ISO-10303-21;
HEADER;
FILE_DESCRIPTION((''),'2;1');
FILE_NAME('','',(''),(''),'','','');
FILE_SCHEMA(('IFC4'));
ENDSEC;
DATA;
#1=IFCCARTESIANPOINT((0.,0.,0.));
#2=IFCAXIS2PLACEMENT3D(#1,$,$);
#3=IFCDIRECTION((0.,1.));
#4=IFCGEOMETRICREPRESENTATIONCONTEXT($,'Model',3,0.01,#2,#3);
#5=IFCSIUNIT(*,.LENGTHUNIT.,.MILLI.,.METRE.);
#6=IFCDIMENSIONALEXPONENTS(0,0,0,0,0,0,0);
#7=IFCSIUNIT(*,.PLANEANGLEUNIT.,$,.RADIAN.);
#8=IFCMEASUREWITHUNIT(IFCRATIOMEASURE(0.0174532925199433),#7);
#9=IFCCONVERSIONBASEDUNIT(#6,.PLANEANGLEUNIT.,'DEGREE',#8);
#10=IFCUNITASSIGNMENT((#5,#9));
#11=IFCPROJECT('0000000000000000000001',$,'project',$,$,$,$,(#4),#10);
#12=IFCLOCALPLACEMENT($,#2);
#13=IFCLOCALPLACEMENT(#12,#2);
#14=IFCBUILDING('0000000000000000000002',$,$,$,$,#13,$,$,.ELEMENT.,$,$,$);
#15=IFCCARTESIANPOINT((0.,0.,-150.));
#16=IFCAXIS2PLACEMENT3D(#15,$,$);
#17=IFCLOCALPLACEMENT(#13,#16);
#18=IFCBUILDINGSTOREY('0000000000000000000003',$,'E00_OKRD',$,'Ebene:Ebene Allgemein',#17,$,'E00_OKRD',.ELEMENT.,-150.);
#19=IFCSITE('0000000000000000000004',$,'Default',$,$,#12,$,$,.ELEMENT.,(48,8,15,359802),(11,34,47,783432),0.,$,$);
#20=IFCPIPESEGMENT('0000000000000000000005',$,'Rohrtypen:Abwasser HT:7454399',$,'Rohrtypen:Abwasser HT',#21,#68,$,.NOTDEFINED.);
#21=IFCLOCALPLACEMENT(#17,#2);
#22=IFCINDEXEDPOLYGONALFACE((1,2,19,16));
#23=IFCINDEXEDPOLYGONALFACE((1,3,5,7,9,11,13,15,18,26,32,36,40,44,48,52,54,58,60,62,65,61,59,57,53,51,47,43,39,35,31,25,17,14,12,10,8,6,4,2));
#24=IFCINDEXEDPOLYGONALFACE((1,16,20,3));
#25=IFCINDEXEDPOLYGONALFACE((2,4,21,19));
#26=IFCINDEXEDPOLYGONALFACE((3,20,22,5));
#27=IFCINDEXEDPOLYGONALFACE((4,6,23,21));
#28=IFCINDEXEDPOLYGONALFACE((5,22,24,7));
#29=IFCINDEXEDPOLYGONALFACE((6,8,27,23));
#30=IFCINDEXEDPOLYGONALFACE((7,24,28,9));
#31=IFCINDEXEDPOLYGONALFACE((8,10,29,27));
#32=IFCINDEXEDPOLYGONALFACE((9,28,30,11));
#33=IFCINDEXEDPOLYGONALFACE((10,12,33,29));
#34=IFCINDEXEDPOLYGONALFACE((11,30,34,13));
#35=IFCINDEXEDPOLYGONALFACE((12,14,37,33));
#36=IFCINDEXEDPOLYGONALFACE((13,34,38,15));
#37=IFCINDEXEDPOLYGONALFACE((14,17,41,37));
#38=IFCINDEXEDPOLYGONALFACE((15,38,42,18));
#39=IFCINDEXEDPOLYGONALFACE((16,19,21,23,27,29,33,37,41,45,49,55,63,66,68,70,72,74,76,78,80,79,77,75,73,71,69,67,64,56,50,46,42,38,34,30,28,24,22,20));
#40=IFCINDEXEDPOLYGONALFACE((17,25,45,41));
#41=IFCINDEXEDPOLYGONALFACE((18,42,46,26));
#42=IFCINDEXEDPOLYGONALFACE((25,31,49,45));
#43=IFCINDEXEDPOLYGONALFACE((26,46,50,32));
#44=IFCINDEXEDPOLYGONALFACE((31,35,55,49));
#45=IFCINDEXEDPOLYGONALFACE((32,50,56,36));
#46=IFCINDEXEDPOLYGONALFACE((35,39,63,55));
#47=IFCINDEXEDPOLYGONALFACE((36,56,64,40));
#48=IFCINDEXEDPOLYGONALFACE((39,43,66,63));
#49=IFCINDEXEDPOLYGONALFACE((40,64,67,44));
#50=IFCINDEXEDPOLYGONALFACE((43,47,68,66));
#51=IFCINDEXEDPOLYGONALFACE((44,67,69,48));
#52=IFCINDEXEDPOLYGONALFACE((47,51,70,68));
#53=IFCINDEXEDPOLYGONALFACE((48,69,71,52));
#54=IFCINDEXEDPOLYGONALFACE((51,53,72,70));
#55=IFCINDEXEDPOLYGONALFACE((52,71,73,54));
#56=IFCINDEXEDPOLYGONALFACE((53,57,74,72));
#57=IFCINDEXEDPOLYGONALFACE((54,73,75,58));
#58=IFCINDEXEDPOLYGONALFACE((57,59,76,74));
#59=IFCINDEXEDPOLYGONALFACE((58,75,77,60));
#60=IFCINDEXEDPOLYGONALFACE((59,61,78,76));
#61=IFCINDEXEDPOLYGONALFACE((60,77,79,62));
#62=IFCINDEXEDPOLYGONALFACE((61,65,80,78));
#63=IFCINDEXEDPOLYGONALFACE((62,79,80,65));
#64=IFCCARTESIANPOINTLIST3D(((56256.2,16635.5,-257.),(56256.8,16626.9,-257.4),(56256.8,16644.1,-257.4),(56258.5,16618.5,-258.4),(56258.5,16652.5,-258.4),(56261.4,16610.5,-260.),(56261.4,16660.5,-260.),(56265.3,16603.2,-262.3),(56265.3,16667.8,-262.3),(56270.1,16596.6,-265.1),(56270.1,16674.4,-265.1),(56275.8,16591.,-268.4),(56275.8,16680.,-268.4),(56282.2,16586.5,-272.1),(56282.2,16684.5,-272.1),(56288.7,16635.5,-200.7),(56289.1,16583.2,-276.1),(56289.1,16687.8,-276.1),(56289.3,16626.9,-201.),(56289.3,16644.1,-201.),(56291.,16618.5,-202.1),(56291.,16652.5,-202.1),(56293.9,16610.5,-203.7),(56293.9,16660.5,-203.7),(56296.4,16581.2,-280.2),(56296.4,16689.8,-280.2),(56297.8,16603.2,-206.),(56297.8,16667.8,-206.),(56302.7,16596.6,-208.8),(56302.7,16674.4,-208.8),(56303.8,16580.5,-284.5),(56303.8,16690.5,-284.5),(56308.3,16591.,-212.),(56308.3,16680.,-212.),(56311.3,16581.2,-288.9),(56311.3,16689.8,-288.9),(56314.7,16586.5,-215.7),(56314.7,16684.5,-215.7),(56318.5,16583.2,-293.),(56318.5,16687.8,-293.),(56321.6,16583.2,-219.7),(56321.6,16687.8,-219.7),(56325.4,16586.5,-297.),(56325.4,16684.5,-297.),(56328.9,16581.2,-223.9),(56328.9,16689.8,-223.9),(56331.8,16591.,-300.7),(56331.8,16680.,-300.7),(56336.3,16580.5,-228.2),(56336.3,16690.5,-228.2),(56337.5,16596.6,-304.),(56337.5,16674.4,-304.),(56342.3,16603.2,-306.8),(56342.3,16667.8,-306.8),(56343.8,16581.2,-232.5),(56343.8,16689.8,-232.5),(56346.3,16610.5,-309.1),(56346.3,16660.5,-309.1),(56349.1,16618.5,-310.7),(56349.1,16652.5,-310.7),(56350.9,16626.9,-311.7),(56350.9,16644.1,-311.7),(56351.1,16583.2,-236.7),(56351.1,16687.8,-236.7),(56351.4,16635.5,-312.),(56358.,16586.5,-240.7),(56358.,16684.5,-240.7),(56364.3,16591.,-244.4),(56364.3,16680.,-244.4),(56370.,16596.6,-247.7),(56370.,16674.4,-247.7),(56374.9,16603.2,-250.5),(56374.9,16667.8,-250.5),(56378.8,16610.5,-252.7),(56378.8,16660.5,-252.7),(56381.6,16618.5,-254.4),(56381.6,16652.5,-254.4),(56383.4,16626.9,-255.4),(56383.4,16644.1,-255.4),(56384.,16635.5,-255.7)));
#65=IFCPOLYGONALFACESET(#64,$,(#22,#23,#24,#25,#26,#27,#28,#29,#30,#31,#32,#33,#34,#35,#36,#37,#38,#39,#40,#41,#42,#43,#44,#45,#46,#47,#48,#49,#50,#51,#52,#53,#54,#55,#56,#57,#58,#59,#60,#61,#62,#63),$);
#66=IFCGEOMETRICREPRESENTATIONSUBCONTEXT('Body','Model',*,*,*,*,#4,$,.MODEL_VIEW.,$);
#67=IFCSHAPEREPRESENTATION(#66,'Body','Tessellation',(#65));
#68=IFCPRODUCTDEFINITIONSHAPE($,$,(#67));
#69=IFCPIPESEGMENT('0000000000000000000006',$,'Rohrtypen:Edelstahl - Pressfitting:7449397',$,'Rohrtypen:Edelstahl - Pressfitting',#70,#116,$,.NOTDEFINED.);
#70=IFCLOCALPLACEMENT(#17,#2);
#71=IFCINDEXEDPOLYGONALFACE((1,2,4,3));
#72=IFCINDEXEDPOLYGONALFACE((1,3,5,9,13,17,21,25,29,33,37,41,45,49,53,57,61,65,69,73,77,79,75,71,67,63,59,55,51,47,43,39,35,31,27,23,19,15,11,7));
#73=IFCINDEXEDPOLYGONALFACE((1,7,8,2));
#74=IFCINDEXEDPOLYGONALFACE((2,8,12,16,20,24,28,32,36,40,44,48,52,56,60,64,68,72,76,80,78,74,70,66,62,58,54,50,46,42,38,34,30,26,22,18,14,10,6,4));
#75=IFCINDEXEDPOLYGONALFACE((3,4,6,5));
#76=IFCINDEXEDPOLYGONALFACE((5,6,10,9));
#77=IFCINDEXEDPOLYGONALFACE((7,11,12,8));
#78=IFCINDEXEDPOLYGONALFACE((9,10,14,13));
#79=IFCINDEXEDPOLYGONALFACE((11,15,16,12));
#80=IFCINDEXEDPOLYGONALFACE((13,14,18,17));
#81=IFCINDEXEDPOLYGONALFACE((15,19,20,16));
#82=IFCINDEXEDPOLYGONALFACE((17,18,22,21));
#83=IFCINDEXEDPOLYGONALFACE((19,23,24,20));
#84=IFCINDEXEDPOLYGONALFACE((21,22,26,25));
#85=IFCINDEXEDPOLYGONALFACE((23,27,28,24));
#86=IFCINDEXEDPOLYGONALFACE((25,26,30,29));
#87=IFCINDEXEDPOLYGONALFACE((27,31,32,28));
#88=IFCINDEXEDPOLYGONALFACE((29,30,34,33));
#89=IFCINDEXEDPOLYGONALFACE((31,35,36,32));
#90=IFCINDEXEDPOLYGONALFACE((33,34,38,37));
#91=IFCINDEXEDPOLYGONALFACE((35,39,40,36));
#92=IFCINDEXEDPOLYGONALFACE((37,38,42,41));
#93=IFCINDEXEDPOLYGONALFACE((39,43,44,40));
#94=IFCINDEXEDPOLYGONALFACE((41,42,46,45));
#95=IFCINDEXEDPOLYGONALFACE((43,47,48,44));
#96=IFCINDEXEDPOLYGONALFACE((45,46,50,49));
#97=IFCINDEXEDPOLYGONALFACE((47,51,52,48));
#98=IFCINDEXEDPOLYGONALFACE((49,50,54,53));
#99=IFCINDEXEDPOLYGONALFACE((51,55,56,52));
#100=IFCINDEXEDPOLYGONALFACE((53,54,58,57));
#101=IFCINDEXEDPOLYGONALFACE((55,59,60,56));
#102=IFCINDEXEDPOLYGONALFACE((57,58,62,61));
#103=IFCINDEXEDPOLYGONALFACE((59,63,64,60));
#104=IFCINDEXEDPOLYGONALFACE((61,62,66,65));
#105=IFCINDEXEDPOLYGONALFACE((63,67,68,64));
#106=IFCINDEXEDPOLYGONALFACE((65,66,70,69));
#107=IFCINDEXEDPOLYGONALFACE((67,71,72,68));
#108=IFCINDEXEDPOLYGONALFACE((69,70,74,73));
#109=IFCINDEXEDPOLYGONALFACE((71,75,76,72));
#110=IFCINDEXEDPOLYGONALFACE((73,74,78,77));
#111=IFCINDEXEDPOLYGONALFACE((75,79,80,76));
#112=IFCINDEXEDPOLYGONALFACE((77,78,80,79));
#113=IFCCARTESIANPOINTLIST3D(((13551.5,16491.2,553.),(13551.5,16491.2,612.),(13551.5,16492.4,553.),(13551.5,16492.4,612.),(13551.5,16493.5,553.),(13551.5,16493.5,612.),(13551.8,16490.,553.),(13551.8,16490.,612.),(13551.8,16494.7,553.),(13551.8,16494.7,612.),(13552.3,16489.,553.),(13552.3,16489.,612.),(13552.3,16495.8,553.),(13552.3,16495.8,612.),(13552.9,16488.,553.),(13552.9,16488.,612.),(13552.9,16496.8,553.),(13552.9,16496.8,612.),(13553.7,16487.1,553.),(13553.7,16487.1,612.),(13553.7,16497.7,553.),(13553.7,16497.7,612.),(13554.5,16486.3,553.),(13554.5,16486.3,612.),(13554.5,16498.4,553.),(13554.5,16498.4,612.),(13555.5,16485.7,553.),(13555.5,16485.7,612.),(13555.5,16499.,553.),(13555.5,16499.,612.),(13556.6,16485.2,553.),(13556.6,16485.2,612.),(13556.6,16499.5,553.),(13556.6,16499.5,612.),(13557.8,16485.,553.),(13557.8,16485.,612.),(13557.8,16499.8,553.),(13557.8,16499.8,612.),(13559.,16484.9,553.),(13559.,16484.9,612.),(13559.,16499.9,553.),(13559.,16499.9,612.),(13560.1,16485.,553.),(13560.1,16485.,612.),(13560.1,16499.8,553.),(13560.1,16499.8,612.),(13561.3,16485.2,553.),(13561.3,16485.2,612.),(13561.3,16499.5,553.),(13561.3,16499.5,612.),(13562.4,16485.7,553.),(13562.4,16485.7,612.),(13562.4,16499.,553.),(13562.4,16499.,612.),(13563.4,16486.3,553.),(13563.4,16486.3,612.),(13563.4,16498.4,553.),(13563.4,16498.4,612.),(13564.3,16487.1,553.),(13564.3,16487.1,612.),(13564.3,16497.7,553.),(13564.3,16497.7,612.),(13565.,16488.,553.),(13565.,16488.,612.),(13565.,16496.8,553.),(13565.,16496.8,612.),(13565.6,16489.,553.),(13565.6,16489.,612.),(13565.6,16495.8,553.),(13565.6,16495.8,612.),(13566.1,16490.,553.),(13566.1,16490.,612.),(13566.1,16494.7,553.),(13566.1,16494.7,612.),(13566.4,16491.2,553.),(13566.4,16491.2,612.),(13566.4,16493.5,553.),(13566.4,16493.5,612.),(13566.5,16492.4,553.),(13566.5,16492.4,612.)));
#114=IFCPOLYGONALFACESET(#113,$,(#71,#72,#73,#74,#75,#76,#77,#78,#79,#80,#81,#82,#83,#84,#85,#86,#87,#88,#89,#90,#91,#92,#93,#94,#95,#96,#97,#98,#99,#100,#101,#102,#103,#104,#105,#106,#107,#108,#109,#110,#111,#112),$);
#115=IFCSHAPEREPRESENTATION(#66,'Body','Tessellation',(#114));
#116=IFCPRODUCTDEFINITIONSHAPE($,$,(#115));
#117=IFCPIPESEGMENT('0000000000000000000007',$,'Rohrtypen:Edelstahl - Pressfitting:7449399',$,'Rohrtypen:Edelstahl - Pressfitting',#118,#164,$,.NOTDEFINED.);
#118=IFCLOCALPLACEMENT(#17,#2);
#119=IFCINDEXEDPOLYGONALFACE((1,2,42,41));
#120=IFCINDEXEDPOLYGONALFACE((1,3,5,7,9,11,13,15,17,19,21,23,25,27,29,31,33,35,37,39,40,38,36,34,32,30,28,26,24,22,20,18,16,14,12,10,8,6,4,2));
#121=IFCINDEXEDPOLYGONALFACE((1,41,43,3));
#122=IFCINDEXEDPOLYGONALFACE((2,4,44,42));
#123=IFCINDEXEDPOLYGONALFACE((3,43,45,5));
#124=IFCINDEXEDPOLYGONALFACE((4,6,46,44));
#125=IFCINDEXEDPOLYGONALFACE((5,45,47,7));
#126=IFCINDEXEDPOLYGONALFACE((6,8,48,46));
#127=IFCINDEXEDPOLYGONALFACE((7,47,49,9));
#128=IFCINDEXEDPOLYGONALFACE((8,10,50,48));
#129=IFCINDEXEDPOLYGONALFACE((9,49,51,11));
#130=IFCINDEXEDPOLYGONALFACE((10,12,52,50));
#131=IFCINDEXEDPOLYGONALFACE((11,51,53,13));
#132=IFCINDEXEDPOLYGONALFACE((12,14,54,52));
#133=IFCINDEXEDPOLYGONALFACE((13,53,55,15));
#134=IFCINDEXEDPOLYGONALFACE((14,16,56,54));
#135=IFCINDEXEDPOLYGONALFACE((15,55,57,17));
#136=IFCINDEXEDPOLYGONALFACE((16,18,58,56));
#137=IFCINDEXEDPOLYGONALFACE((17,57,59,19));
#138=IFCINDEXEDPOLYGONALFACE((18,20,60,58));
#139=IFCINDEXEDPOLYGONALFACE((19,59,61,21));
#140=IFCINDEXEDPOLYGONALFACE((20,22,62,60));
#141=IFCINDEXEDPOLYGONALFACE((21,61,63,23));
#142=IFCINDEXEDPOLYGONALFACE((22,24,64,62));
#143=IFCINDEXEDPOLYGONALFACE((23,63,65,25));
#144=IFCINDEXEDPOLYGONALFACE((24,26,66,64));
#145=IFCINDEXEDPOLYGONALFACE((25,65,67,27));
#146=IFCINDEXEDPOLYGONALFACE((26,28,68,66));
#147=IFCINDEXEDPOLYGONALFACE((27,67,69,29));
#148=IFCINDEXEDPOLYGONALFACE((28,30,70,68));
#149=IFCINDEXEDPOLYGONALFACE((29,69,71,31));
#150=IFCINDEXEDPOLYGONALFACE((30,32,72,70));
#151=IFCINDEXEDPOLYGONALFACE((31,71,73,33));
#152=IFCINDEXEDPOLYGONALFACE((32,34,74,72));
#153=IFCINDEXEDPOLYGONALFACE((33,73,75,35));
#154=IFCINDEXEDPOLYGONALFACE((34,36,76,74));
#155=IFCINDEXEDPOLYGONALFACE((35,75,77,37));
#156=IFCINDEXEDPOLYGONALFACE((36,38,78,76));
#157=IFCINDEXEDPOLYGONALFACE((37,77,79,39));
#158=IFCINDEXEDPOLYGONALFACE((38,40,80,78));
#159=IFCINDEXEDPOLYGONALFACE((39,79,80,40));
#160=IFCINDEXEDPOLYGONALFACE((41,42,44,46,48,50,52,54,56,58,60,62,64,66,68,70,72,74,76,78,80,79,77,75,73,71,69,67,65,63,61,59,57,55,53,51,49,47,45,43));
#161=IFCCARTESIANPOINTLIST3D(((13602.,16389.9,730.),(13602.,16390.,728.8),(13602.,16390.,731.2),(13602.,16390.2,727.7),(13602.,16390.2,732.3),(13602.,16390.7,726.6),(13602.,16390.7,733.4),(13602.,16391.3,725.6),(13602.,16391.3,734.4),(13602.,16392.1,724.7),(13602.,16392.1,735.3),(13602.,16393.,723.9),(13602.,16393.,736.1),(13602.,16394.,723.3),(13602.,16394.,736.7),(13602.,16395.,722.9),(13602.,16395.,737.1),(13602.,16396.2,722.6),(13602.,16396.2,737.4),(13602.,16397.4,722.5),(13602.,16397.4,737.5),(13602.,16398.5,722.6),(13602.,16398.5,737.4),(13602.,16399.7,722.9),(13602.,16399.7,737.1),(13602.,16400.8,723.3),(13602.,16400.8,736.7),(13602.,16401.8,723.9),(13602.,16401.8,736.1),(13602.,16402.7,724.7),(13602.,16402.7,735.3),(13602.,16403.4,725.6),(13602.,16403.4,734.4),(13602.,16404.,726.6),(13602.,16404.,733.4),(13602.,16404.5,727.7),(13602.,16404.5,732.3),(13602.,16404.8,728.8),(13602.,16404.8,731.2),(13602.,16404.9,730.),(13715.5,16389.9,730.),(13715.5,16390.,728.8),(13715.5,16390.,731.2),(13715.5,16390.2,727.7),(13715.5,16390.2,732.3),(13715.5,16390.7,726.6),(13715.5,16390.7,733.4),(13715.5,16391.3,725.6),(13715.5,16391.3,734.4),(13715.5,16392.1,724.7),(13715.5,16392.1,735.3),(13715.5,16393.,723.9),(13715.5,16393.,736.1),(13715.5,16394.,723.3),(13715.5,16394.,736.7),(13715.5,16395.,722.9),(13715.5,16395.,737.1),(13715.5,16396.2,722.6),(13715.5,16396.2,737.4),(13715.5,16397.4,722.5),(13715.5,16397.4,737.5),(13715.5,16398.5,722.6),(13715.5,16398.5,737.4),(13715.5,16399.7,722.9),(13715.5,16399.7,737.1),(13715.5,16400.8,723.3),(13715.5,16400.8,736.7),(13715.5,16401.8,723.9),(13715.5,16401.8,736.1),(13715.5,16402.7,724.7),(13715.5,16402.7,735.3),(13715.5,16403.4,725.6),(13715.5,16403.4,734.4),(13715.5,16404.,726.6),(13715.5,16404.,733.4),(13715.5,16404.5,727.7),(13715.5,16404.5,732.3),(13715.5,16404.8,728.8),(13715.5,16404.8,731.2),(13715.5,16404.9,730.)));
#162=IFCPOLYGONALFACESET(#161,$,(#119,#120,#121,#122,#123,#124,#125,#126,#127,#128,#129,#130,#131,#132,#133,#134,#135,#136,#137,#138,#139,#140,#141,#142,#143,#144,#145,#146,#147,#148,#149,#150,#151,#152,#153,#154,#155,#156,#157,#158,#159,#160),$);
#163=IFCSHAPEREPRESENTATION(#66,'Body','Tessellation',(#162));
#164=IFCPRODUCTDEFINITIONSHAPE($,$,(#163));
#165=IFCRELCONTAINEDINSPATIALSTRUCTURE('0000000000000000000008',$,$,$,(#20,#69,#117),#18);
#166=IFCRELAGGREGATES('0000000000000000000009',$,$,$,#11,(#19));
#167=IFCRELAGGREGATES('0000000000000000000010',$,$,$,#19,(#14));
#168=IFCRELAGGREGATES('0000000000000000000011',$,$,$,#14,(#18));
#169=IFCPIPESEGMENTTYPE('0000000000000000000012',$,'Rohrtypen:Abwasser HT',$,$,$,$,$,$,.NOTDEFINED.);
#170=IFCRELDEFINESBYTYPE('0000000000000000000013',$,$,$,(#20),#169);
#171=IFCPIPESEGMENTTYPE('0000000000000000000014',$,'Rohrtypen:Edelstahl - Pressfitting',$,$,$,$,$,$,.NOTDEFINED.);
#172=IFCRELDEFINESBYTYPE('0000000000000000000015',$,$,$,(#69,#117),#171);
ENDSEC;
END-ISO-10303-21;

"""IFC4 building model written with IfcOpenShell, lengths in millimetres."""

from ifc_helpers import new_model, entity, si_unit, converted_unit, direction, frame, origin, place, context, subcontext, project, spatial, indexed_curve, outline, extrude, type_object, element, save


model = new_model("IFC4")

# Units and contexts
model_context = context("Model", 3, precision=0.01, world=origin(), true_north=direction((0.0, 1.0)))
body_context = subcontext(model_context, "Body", "Model", "MODEL_VIEW")
ifc_project = project(units=[si_unit("LENGTHUNIT", "METRE", prefix="MILLI"), converted_unit("PLANEANGLEUNIT", "DEGREE", entity("IfcRatioMeasure", 0.0174532925199433), si_unit("PLANEANGLEUNIT", "RADIAN"), dimensions=[0, 0, 0, 0, 0, 0, 0])], contexts=[model_context])

# Site, building, storey
site_placement = place(None, origin())
site = spatial("IfcSite", under=ifc_project, at=site_placement, Name="Default", CompositionType="ELEMENT", RefLatitude=(48, 8, 15, 359802), RefLongitude=(11, 34, 47, 783432), RefElevation=0.0)
building_placement = place(site_placement, origin())
building = spatial("IfcBuilding", under=site, at=building_placement, CompositionType="ELEMENT")
storey_placement = place(building_placement, frame((0.0, 0.0, -150.0)))
storey = spatial("IfcBuildingStorey", under=building, at=storey_placement, Name="E00_OKRD", ObjectType="Ebene:Ebene Allgemein", LongName="E00_OKRD", CompositionType="ELEMENT", Elevation=-150.0)

# Pipe segments
pipe_segment_type_1 = type_object("IfcPipeSegmentType", Name="Rohrtypen:Abwasser HT", PredefinedType="NOTDEFINED")
pipe_segment_1_placement = place(storey_placement, origin())
element("IfcPipeSegment", 1, at=pipe_segment_1_placement, inside=storey, type_object=pipe_segment_type_1, Name="Rohrtypen:Abwasser HT:7454399", ObjectType="Rohrtypen:Abwasser HT", PredefinedType="NOTDEFINED", context=body_context, shape_type="SweptSolid", body=[
    extrude(outline(indexed_curve([(55.0, 0.0), (54.3, 8.6), (52.3, 17.0), (49.0, 25.0), (44.5, 32.3), (38.9, 38.9), (32.3, 44.5), (25.0, 49.0), (17.0, 52.3), (8.6, 54.3), (0.0, 55.0), (-8.6, 54.3), (-17.0, 52.3), (-25.0, 49.0), (-32.3, 44.5), (-38.9, 38.9), (-44.5, 32.3), (-49.0, 25.0), (-52.3, 17.0), (-54.3, 8.6), (-55.0, 0.0), (-54.3, -8.6), (-52.3, -17.0), (-49.0, -25.0), (-44.5, -32.3), (-38.9, -38.9), (-32.3, -44.5), (-25.0, -49.0), (-17.0, -52.3), (-8.6, -54.3), (0.0, -55.0), (8.6, -54.3), (17.0, -52.3), (25.0, -49.0), (32.3, -44.5), (38.9, -38.9), (44.5, -32.3), (49.0, -25.0), (52.3, -17.0), (54.3, -8.6), (55.0, 0.0)], self_intersect=False)), frame((56303.8, 16635.5, -284.5), z_axis=(0.5, 0.0, 0.866025), x_axis=(0.0, 1.0, 0.0)), (0.0, 0.0, 1.0), 65.1),
])
pipe_segment_type_2 = type_object("IfcPipeSegmentType", Name="Rohrtypen:Edelstahl - Pressfitting", PredefinedType="NOTDEFINED")
pipe_segment_2_placement = place(storey_placement, origin())
element("IfcPipeSegment", 2, at=pipe_segment_2_placement, inside=storey, type_object=pipe_segment_type_2, Name="Rohrtypen:Edelstahl - Pressfitting:7449397", ObjectType="Rohrtypen:Edelstahl - Pressfitting", PredefinedType="NOTDEFINED", context=body_context, shape_type="SweptSolid", body=[
    extrude(outline(indexed_curve([(7.5, 0.0), (7.4, 1.2), (7.1, 2.3), (6.7, 3.4), (6.1, 4.4), (5.3, 5.3), (4.4, 6.1), (3.4, 6.7), (2.3, 7.1), (1.2, 7.4), (0.0, 7.5), (-1.2, 7.4), (-2.3, 7.1), (-3.4, 6.7), (-4.4, 6.1), (-5.3, 5.3), (-6.1, 4.4), (-6.7, 3.4), (-7.1, 2.3), (-7.4, 1.2), (-7.5, 0.0), (-7.4, -1.2), (-7.1, -2.3), (-6.7, -3.4), (-6.1, -4.4), (-5.3, -5.3), (-4.4, -6.1), (-3.4, -6.7), (-2.3, -7.1), (-1.2, -7.4), (0.0, -7.5), (1.2, -7.4), (2.3, -7.1), (3.4, -6.7), (4.4, -6.1), (5.3, -5.3), (6.1, -4.4), (6.7, -3.4), (7.1, -2.3), (7.4, -1.2), (7.5, 0.0)], self_intersect=False)), frame((13559.0, 16492.4, 553.0)), (0.0, 0.0, 1.0), 59.0),
])
pipe_segment_3_placement = place(storey_placement, origin())
element("IfcPipeSegment", 3, at=pipe_segment_3_placement, inside=storey, type_object=pipe_segment_type_2, Name="Rohrtypen:Edelstahl - Pressfitting:7449399", ObjectType="Rohrtypen:Edelstahl - Pressfitting", PredefinedType="NOTDEFINED", context=body_context, shape_type="SweptSolid", body=[
    extrude(outline(indexed_curve([(7.5, 0.0), (7.4, 1.2), (7.1, 2.3), (6.7, 3.4), (6.1, 4.4), (5.3, 5.3), (4.4, 6.1), (3.4, 6.7), (2.3, 7.1), (1.2, 7.4), (0.0, 7.5), (-1.2, 7.4), (-2.3, 7.1), (-3.4, 6.7), (-4.4, 6.1), (-5.3, 5.3), (-6.1, 4.4), (-6.7, 3.4), (-7.1, 2.3), (-7.4, 1.2), (-7.5, 0.0), (-7.4, -1.2), (-7.1, -2.3), (-6.7, -3.4), (-6.1, -4.4), (-5.3, -5.3), (-4.4, -6.1), (-3.4, -6.7), (-2.3, -7.1), (-1.2, -7.4), (0.0, -7.5), (1.2, -7.4), (2.3, -7.1), (3.4, -6.7), (4.4, -6.1), (5.3, -5.3), (6.1, -4.4), (6.7, -3.4), (7.1, -2.3), (7.4, -1.2), (7.5, 0.0)], self_intersect=False)), frame((13602.0, 16397.4, 730.0), z_axis=(1.0, 0.0, 0.0), x_axis=(0.0, -1.0, 0.0)), (0.0, 0.0, 1.0), 113.6),
])

save(model, "model.ifc")
